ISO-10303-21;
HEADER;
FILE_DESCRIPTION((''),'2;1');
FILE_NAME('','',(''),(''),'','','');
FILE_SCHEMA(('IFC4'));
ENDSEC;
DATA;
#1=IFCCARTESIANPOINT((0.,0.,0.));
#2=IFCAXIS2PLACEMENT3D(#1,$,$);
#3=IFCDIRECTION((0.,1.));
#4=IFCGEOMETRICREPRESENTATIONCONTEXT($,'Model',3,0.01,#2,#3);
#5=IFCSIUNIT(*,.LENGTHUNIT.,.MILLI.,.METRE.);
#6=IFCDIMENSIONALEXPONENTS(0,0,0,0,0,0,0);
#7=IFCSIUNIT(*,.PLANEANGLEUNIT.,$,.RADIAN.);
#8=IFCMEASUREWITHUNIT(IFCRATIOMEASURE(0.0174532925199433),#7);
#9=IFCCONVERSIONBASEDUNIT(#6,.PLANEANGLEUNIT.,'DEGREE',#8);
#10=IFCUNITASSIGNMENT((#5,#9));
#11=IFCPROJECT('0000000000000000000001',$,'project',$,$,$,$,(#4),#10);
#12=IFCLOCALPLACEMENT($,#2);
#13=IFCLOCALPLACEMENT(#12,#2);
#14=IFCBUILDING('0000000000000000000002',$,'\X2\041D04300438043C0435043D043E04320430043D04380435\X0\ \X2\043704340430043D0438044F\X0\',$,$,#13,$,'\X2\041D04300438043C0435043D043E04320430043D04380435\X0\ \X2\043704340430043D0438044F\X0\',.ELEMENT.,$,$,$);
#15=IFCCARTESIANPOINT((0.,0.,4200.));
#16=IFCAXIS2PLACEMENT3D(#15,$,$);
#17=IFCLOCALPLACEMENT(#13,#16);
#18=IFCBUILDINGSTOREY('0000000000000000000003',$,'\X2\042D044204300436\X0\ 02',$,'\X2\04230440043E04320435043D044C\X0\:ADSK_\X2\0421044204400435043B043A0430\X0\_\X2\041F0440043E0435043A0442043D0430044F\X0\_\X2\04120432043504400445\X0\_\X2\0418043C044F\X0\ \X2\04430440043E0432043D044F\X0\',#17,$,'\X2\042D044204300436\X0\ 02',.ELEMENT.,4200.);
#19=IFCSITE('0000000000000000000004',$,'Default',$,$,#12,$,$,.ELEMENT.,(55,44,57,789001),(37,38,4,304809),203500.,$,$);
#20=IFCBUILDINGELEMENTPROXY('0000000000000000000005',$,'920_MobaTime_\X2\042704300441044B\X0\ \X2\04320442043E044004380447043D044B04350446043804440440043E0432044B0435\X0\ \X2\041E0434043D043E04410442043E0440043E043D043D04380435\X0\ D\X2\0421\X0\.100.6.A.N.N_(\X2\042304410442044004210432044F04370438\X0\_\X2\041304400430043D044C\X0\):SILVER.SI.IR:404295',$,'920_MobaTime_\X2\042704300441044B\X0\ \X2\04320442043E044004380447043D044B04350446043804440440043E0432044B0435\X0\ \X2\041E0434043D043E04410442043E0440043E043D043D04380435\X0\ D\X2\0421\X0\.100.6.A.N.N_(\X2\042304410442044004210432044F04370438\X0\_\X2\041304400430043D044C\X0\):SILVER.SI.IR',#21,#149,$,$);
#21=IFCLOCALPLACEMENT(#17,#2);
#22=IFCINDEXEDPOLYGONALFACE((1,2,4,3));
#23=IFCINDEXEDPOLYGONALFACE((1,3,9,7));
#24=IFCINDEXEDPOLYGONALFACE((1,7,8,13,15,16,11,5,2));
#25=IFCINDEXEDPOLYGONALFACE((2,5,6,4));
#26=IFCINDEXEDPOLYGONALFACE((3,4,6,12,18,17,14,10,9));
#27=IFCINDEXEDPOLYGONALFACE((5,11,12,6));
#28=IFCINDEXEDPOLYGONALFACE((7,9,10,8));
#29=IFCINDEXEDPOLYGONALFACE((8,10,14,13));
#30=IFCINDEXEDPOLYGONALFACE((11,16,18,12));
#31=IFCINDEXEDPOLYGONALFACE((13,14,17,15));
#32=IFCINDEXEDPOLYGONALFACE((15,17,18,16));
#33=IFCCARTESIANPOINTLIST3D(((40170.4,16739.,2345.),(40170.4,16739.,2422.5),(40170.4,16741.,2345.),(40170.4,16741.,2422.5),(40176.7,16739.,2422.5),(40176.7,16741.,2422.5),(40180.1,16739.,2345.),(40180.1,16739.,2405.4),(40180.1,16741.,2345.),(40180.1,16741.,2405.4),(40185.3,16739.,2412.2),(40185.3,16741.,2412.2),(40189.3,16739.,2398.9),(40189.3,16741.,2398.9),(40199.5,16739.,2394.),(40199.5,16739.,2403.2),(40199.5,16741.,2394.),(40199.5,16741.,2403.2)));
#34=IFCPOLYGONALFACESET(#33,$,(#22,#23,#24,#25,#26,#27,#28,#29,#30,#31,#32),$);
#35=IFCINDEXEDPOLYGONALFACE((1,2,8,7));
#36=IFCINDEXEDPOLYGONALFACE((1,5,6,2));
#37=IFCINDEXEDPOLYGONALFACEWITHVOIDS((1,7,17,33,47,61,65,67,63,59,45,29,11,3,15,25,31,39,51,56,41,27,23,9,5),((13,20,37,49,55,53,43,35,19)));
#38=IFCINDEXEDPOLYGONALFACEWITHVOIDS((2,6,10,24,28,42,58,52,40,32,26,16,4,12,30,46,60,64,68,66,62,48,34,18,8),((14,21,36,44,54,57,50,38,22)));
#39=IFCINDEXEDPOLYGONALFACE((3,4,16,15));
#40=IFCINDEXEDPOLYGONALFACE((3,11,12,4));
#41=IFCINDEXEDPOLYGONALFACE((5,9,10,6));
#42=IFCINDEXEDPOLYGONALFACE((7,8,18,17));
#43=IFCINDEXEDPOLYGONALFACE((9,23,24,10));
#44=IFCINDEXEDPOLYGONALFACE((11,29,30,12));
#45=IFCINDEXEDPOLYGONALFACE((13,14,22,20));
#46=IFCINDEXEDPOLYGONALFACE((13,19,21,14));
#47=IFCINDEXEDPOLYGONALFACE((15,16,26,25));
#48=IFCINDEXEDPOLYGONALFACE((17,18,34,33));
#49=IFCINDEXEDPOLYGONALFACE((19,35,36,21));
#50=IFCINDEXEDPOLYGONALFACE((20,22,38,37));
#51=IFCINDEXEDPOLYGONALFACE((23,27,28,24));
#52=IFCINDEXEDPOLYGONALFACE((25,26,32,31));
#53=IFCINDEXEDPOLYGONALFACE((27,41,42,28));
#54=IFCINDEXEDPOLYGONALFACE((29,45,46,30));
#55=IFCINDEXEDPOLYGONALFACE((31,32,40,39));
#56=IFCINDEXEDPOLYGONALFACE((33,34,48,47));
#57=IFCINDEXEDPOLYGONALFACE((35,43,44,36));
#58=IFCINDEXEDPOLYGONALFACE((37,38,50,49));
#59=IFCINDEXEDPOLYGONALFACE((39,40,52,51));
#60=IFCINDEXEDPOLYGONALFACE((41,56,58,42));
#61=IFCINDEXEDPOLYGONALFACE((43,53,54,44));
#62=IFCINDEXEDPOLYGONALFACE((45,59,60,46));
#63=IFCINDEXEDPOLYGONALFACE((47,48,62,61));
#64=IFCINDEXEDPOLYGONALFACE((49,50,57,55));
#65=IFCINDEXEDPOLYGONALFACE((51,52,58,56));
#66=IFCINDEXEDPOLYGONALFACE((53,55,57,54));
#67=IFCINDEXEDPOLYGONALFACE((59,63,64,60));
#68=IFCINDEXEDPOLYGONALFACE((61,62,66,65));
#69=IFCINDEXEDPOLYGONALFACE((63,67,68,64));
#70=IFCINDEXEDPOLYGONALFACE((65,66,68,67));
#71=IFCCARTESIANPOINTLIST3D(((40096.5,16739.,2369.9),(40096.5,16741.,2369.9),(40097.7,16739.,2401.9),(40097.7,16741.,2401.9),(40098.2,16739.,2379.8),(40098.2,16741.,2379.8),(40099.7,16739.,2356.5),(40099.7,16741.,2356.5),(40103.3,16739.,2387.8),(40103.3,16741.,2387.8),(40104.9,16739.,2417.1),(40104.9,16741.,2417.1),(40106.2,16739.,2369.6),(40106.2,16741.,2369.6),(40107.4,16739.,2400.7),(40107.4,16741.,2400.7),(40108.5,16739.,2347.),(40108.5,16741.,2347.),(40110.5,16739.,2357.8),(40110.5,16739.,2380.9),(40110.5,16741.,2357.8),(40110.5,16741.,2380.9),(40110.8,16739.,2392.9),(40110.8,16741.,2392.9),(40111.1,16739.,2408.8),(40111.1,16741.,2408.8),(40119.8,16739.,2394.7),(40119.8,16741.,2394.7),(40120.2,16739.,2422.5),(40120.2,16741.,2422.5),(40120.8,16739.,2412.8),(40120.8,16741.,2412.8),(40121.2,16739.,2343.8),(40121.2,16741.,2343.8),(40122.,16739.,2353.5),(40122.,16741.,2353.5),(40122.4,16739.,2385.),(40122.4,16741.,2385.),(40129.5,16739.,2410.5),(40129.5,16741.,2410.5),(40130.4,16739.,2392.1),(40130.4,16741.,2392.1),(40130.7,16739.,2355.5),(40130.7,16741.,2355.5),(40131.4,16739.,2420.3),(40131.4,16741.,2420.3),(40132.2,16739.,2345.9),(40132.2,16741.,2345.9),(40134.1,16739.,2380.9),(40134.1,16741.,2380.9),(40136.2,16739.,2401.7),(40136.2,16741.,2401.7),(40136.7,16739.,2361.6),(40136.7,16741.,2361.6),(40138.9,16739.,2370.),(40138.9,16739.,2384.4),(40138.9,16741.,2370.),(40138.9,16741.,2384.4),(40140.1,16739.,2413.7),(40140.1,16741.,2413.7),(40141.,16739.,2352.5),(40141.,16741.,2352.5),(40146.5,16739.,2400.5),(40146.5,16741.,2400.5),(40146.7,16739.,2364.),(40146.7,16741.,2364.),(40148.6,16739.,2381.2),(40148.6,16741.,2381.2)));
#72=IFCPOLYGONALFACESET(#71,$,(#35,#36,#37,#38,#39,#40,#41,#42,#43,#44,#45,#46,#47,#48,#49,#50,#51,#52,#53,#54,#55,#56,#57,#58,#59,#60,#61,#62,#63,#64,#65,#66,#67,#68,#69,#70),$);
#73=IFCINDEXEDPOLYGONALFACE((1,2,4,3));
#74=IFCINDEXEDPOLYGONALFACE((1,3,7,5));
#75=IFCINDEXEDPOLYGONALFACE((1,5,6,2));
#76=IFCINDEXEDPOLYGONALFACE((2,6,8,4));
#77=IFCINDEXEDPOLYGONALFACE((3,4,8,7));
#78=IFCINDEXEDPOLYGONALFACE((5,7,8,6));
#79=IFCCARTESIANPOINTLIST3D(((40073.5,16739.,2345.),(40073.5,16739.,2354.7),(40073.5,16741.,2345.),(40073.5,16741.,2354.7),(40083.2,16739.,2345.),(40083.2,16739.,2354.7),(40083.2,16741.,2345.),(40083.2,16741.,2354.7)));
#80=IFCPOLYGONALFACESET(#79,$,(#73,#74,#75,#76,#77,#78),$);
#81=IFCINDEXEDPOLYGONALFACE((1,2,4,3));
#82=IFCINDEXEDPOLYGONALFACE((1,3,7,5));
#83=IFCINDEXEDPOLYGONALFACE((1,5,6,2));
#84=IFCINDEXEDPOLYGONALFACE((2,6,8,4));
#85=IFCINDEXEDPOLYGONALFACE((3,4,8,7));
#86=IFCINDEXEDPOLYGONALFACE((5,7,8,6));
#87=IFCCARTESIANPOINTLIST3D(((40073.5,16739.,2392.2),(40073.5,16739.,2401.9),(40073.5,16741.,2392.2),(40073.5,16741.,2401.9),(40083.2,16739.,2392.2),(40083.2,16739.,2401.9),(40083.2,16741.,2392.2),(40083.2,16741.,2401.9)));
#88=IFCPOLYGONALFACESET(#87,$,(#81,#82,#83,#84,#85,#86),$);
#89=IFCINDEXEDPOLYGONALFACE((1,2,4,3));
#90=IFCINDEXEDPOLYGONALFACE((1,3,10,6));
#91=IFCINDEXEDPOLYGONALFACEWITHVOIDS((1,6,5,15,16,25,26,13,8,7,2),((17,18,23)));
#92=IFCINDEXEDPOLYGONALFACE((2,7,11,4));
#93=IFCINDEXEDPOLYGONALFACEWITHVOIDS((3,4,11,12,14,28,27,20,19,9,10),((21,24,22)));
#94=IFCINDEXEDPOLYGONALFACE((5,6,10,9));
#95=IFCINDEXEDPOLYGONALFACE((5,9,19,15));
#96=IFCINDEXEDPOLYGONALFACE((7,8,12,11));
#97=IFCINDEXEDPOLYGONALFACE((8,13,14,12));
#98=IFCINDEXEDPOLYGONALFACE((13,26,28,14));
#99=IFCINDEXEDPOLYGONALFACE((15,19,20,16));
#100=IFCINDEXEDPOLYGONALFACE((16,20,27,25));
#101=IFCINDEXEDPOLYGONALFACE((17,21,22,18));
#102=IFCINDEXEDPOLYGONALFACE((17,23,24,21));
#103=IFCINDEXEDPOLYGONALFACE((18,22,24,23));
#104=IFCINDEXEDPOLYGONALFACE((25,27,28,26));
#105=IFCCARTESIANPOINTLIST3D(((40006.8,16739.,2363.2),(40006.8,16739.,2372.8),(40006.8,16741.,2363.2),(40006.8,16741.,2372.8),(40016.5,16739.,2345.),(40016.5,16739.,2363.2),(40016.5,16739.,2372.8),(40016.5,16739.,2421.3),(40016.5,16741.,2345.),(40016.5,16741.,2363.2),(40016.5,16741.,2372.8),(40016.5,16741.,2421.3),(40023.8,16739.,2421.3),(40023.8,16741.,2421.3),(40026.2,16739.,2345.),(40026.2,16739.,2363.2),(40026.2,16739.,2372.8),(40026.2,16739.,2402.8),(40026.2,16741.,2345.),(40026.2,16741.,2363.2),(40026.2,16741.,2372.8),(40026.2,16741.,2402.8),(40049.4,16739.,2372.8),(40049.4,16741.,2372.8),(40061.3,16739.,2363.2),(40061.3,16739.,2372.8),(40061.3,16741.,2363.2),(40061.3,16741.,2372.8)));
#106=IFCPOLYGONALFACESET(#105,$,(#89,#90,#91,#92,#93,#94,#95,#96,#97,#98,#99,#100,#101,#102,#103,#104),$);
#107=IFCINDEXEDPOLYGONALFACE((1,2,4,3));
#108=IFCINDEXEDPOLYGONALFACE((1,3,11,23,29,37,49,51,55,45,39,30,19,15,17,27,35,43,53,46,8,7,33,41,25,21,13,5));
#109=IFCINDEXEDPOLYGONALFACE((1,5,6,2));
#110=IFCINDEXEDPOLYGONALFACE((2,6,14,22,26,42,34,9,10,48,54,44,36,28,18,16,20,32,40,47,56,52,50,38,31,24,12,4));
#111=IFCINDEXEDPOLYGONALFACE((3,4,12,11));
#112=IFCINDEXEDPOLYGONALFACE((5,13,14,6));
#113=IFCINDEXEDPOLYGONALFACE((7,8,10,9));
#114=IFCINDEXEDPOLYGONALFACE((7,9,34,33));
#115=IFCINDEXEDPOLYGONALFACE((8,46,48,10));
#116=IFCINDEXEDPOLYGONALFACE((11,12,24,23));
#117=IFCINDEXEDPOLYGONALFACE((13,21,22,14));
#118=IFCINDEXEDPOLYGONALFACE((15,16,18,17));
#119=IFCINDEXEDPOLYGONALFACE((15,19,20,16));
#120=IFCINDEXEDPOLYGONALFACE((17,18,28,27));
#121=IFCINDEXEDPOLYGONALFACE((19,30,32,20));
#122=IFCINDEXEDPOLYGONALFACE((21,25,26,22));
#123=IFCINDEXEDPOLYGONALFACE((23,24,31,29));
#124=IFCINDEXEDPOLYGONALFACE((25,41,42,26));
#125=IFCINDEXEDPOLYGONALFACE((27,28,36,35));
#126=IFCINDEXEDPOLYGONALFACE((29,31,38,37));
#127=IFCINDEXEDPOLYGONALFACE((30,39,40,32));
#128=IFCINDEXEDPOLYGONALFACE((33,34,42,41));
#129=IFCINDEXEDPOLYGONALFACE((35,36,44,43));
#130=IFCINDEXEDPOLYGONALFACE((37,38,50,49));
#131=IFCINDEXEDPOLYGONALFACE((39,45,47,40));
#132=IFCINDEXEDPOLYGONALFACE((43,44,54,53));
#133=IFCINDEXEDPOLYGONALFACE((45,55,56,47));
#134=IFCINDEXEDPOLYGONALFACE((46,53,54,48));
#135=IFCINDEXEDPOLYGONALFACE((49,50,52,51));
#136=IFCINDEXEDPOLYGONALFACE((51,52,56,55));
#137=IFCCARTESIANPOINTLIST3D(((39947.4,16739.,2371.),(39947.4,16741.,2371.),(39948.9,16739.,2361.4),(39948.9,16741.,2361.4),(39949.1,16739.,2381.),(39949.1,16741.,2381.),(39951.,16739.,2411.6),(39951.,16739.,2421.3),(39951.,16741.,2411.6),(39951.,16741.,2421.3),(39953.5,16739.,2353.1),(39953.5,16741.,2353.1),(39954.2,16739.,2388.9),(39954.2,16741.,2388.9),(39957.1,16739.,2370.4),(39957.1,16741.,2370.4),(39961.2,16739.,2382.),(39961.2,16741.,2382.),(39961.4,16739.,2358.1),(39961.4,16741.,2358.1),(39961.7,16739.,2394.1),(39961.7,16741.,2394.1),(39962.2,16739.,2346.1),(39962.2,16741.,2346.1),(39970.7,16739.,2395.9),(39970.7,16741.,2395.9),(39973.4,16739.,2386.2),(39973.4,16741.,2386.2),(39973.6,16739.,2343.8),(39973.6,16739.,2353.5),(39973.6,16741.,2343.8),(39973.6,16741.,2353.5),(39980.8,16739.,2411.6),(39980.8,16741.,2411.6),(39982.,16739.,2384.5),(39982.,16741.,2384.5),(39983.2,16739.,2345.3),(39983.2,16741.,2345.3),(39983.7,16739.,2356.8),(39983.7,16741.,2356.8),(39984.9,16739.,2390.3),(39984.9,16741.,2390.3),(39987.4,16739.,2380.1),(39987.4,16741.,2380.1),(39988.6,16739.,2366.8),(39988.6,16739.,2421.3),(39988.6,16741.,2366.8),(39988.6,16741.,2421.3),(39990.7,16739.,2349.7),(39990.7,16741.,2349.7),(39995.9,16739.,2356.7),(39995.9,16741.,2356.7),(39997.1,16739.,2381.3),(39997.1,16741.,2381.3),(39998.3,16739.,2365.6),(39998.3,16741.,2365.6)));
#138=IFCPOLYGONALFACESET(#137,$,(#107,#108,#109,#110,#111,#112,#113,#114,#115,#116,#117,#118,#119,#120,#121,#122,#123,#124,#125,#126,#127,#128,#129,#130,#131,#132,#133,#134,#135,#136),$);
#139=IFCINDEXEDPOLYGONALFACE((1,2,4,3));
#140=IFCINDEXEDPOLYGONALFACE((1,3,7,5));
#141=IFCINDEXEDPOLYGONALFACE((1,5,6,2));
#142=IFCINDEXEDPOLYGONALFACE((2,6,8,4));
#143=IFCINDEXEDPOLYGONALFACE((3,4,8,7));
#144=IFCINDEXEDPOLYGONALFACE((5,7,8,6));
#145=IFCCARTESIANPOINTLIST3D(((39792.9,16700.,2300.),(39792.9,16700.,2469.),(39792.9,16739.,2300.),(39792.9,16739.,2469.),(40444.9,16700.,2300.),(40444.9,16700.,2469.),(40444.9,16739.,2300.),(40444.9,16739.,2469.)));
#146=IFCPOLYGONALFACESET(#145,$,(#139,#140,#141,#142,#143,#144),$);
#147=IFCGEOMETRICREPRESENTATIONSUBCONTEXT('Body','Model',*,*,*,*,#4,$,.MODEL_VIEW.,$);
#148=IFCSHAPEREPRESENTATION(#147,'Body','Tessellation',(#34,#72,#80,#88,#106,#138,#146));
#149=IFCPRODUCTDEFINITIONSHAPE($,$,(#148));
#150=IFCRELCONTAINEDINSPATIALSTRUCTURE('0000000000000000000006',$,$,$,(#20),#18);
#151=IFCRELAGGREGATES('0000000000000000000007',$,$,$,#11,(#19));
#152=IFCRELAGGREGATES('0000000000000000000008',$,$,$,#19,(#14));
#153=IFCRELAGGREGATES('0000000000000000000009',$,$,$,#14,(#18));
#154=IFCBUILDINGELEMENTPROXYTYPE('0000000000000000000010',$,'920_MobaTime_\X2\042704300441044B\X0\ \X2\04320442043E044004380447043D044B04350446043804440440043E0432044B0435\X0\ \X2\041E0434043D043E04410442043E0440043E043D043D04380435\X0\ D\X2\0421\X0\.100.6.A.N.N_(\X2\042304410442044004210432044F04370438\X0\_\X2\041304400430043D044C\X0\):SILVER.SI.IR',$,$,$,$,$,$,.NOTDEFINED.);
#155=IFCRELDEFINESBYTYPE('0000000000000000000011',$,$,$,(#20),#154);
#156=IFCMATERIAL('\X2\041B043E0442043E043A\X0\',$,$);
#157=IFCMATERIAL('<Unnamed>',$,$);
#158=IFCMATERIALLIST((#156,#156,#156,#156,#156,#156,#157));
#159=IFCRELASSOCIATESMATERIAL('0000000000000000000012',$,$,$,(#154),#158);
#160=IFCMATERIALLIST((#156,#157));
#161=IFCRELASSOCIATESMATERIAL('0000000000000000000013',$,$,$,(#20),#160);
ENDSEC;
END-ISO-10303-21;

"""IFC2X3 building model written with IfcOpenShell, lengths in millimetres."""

from ifc_helpers import new_model, entity, si_unit, converted_unit, direction, frame, origin, origin_2d_with_axis, place, context, subcontext, project, spatial, polyline, rectangle, outline, extrude, source, transform, mapped, material, material_list, type_object, type_shapes, element, save


model = new_model("IFC2X3")

# Units and contexts
model_context = context("Model", 3, precision=0.01, world=origin(), true_north=direction((0.0, 1.0)))
body_context = subcontext(model_context, "Body", "Model", "MODEL_VIEW")
ifc_project = project(units=[si_unit("LENGTHUNIT", "METRE", prefix="MILLI"), converted_unit("PLANEANGLEUNIT", "DEGREE", entity("IfcRatioMeasure", 0.0174532925199433), si_unit("PLANEANGLEUNIT", "RADIAN"), dimensions=[0, 0, 0, 0, 0, 0, 0])], contexts=[model_context])

# Site, building, storey
site_placement = place(None, frame((0.0, 0.0, 0.0)))
site = spatial("IfcSite", under=ifc_project, at=site_placement, Name="Default", CompositionType="ELEMENT", RefLatitude=(55, 44, 57, 789001), RefLongitude=(37, 38, 4, 304809), RefElevation=203500.0)
building_placement = place(site_placement, origin())
building = spatial("IfcBuilding", under=site, at=building_placement, Name="Наименование здания", LongName="Наименование здания", CompositionType="ELEMENT")
storey_placement = place(building_placement, frame((0.0, 0.0, 4200.0)))
storey = spatial("IfcBuildingStorey", under=building, at=storey_placement, Name="Этаж 02", ObjectType="Уровень:ADSK_Стрелка_Проектная_Вверх_Имя уровня", LongName="Этаж 02", CompositionType="ELEMENT", Elevation=4200.0)

# Building element proxy
ifc_material_1 = material(Name="Лоток")
ifc_material_2 = material(Name="<Unnamed>")
ifc_material_list_1 = material_list([ifc_material_1, ifc_material_1, ifc_material_1, ifc_material_1, ifc_material_1, ifc_material_1, ifc_material_2])
building_element_proxy_type_1 = type_object("IfcBuildingElementProxyType", Name="920_MobaTime_Часы вторичныецифровые Односторонние DС.100.6.A.N.N_(УстрСвязи_Грань):SILVER.SI.IR", PredefinedType="NOTDEFINED", material=ifc_material_list_1)
shared_shape_1 = source(origin(), body_context, "Body", "SweptSolid", [
    extrude(outline(polyline([(-49.3, -13.1), (28.2, -13.1), (28.2, -6.8), (17.9, 1.8), (8.9, 16.0), (-0.3, 16.0), (4.6, 5.8), (11.1, -3.4), (-49.3, -3.4), (-49.3, -13.1)])), frame((-64.6, 9.8, 39.0), z_axis=(0.0, 0.0, 1.0), x_axis=(0.0, 1.0, 0.0)), (0.0, 0.0, 1.0), 2.0),
    extrude(outline(polyline([(2.2, -27.6), (19.0, -27.6), (30.5, -16.1), (33.3, -4.9), (31.0, 5.8), (21.8, 17.2), (5.2, 27.3), (-11.1, 33.0), (-24.0, 32.7), (-33.6, 27.6), (-40.3, 18.6), (-42.8, 5.7), (-38.0, -6.3), (-27.2, -15.0), (-17.5, -17.7), (-8.2, -16.4), (-0.3, -11.9), (5.1, -4.5), (7.3, 6.2), (4.0, 17.2), (18.5, 7.3), (23.6, -2.4), (22.0, -11.4), (14.2, -18.4), (5.3, -18.3), (2.2, -27.6)]), holes=[polyline([(-9.0, 23.3), (-1.3, 14.4), (-2.6, 2.0), (-11.4, -7.0), (-23.4, -6.1), (-32.2, 2.9), (-31.2, 15.1), (-25.6, 22.1), (-17.5, 24.9), (-9.0, 23.3)])]), frame((-2.7, 3.6, 39.0), z_axis=(0.0, 0.0, 1.0), x_axis=(-0.427649, 0.903945, 0.0)), (0.0, 0.0, 1.0), 2.0),
    extrude(rectangle(XDim=9.7, YDim=9.7, at=origin_2d_with_axis()), frame((40.6, -34.7, 39.0)), (0.0, 0.0, 1.0), 2.0),
    extrude(rectangle(XDim=9.7, YDim=9.7, at=origin_2d_with_axis()), frame((40.6, 12.6, 39.0)), (0.0, 0.0, 1.0), 2.0),
    extrude(outline(polyline([(-0.9, -28.1), (8.8, -28.1), (8.8, -9.9), (18.5, -9.9), (18.5, -0.2), (8.8, -0.2), (8.8, 48.3), (1.5, 48.3), (-36.0, -0.2), (-36.0, -9.9), (-0.9, -9.9), (-0.9, -28.1)]), holes=[polyline([(-0.9, -0.2), (-24.1, -0.2), (-0.9, 29.7), (-0.9, -0.2)])]), frame((93.6, -11.4, 39.0)), (0.0, 0.0, 1.0), 2.0),
    extrude(outline(polyline([(3.3, -28.3), (12.5, -28.3), (20.5, -25.0), (26.8, -18.8), (30.7, -10.0), (31.4, 1.6), (26.9, 11.8), (20.1, 18.4), (11.1, 22.3), (1.0, 23.3), (-7.9, 20.4), (-14.9, 14.5), (-18.9, 6.2), (-17.1, -9.0), (-36.7, 0.5), (-29.1, 29.3), (-38.5, 31.7), (-48.1, -4.6), (-11.6, -23.0), (-8.0, -14.0), (-10.8, -7.6), (-10.2, 1.1), (-3.0, 11.8), (9.2, 12.8), (20.0, 5.4), (21.3, -7.5), (15.5, -16.4), (4.6, -18.6), (3.3, -28.3)])), frame((147.1, -8.5, 39.0), z_axis=(0.0, 0.0, 1.0), x_axis=(0.256974, -0.966418, 0.0)), (0.0, 0.0, 1.0), 2.0),
    extrude(rectangle(XDim=652.0, YDim=169.0, at=origin_2d_with_axis()), frame((0.0, 0.0, 0.0), z_axis=(0.0, 0.0, 1.0), x_axis=(-1.0, 0.0, 0.0)), (0.0, 0.0, 1.0), 39.0),
])
type_shapes(building_element_proxy_type_1, [shared_shape_1])
ifc_material_list_2 = material_list([ifc_material_1, ifc_material_2])
proxy_1_placement = place(storey_placement, frame((40118.9, 16700.0, 2384.5), z_axis=(0.0, 1.0, 0.0), x_axis=(-1.0, 0.0, 0.0)))
element("IfcBuildingElementProxy", 1, at=proxy_1_placement, inside=storey, type_object=building_element_proxy_type_1, material=ifc_material_list_2, Name="920_MobaTime_Часы вторичныецифровые Односторонние DС.100.6.A.N.N_(УстрСвязи_Грань):SILVER.SI.IR:404295", ObjectType="920_MobaTime_Часы вторичныецифровые Односторонние DС.100.6.A.N.N_(УстрСвязи_Грань):SILVER.SI.IR", context=body_context, shape_type="MappedRepresentation", body=[
    mapped(shared_shape_1, transform((0.0, 0.0, 0.0), scale=1.0)),
])

save(model, "model.ifc")
